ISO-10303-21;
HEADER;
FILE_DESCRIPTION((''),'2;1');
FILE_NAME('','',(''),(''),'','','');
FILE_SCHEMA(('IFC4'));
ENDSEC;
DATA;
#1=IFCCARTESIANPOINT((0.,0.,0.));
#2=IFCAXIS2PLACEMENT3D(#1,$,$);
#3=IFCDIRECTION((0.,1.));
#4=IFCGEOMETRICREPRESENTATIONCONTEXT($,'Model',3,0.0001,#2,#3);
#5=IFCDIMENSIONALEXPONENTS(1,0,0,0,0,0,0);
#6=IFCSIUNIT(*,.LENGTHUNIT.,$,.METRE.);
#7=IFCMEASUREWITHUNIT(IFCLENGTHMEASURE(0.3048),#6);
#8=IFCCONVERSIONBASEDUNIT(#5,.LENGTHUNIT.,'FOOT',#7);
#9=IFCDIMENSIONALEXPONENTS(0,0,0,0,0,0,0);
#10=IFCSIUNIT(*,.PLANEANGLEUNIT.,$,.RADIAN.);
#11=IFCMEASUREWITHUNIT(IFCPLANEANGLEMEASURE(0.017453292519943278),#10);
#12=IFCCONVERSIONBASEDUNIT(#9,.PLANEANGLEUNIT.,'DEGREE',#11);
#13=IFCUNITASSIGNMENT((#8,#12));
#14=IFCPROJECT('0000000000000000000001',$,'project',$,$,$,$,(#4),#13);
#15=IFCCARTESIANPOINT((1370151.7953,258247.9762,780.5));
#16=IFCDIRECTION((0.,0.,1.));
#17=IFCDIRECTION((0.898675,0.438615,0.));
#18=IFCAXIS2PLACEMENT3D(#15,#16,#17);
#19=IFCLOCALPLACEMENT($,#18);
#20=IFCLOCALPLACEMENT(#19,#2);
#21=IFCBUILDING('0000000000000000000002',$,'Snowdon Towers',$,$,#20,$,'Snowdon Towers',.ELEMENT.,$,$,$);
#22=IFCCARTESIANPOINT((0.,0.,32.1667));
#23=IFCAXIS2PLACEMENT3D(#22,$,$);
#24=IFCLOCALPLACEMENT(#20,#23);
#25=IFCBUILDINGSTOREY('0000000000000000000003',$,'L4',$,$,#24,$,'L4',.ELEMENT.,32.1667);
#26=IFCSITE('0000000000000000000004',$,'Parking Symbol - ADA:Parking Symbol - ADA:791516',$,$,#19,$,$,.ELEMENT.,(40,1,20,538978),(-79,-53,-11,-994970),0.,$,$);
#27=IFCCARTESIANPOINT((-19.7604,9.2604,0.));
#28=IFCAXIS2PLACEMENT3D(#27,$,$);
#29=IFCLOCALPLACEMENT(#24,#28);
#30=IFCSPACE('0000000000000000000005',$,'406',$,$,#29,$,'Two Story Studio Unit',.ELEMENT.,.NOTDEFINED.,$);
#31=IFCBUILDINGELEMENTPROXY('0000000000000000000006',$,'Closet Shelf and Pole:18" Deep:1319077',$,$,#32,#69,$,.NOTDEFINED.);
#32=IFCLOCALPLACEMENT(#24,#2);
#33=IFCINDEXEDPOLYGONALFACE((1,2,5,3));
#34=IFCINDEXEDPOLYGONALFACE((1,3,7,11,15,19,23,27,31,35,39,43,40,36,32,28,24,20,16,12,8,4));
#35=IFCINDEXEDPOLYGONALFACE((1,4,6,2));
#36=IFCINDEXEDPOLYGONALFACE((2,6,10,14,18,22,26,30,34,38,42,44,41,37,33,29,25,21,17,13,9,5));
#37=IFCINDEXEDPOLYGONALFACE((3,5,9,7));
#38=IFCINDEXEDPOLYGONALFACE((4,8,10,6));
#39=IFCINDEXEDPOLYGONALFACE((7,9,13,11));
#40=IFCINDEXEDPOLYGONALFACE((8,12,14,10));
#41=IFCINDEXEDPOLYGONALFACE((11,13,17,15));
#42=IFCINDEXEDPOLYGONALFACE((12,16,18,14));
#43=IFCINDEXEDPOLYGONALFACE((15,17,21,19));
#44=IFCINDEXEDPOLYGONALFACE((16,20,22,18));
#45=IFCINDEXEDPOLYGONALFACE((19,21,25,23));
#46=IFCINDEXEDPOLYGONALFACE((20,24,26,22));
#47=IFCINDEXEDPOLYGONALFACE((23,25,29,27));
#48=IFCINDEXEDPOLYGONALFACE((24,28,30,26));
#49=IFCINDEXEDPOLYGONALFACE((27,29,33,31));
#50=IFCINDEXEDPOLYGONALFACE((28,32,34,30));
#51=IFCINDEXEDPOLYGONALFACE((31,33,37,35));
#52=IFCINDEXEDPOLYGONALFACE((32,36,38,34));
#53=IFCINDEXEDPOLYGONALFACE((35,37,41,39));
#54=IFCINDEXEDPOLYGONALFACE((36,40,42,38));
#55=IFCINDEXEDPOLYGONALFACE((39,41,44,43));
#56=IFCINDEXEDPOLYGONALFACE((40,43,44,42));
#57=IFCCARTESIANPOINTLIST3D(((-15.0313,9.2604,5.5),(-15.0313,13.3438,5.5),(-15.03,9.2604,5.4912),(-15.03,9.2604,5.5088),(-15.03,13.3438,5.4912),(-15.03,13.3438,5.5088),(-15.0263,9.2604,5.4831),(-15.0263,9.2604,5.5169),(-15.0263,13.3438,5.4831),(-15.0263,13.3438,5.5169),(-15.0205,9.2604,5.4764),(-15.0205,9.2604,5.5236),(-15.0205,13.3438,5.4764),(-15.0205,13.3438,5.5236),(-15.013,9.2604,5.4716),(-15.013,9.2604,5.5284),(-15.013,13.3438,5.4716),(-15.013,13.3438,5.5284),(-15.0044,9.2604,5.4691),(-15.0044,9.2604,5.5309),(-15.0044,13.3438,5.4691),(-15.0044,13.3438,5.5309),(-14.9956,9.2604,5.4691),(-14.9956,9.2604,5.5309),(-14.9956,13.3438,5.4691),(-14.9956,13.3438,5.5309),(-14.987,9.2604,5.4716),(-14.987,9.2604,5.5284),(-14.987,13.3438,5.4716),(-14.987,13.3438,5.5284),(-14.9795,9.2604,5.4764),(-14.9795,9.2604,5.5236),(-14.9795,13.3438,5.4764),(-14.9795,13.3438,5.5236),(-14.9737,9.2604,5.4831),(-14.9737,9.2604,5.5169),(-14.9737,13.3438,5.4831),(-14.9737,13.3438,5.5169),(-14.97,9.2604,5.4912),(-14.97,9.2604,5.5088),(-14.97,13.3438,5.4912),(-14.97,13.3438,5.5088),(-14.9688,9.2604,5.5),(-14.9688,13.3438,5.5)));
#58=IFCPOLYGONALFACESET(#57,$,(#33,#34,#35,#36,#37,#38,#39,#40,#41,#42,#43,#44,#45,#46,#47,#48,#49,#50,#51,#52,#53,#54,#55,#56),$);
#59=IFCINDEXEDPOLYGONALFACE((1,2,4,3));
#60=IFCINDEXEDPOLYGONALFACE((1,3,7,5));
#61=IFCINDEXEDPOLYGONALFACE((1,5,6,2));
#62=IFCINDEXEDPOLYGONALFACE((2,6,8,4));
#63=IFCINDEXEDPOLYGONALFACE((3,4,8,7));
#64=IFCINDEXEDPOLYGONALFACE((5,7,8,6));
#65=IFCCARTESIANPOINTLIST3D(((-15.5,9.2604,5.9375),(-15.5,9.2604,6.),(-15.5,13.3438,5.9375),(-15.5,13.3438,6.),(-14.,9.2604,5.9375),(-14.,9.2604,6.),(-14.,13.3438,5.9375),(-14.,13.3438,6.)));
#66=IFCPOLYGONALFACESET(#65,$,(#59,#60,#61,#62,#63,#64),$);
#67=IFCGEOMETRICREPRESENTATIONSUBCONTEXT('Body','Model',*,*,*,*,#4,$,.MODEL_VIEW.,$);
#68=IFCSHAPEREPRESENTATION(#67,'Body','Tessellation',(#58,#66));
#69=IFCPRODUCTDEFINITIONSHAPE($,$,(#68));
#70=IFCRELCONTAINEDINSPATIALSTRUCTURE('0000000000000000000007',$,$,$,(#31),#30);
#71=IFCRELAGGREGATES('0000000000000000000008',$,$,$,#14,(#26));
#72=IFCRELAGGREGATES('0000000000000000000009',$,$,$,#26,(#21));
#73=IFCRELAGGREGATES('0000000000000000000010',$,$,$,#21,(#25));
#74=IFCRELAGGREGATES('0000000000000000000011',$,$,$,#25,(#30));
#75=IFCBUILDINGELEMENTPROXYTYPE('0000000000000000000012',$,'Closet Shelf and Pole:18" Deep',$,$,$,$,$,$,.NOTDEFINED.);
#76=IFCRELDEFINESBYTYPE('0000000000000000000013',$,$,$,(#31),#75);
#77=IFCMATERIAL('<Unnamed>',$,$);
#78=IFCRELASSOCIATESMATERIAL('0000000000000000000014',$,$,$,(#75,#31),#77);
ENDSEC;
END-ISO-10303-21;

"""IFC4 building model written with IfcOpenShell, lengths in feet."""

from ifc_helpers import new_model, entity, si_unit, converted_unit, direction, frame, origin, place, context, subcontext, project, spatial, arc, indexed_curve, outline, extrude, source, transform, mapped, material, type_object, type_shapes, element, save


model = new_model("IFC4")

# Units and contexts
model_context = context("Model", 3, precision=0.0001, world=origin(), true_north=direction((0.0, 1.0)))
body_context = subcontext(model_context, "Body", "Model", "MODEL_VIEW")
ifc_project = project(units=[converted_unit("LENGTHUNIT", "FOOT", entity("IfcLengthMeasure", 0.3048), si_unit("LENGTHUNIT", "METRE"), dimensions=[1, 0, 0, 0, 0, 0, 0]), converted_unit("PLANEANGLEUNIT", "DEGREE", entity("IfcPlaneAngleMeasure", 0.017453292519943278), si_unit("PLANEANGLEUNIT", "RADIAN"), dimensions=[0, 0, 0, 0, 0, 0, 0])], contexts=[model_context])

# Site, building, storey
site_placement = place(None, frame((1370151.7953, 258247.9762, 780.5), z_axis=(0.0, 0.0, 1.0), x_axis=(0.898675, 0.438615, 0.0)))
site = spatial("IfcSite", under=ifc_project, at=site_placement, Name="Parking Symbol - ADA:Parking Symbol - ADA:791516", CompositionType="ELEMENT", RefLatitude=(40, 1, 20, 538978), RefLongitude=(-79, -53, -11, -994970), RefElevation=0.0)
building_placement = place(site_placement, origin())
building = spatial("IfcBuilding", under=site, at=building_placement, Name="Snowdon Towers", LongName="Snowdon Towers", CompositionType="ELEMENT")
storey_placement = place(building_placement, frame((0.0, 0.0, 32.1667)))
storey = spatial("IfcBuildingStorey", under=building, at=storey_placement, Name="L4", LongName="L4", CompositionType="ELEMENT", Elevation=32.1667)

# Shared definitions
space_placement = place(storey_placement, frame((-19.7604, 9.2604, 0.0)))
space = spatial("IfcSpace", under=storey, at=space_placement, Name="406", LongName="Two Story Studio Unit", CompositionType="ELEMENT", PredefinedType="NOTDEFINED")

# Building element proxy
ifc_material_1 = material(Name="<Unnamed>")
building_element_proxy_type_1 = type_object("IfcBuildingElementProxyType", Name="Closet Shelf and Pole:18\" Deep", PredefinedType="NOTDEFINED", material=ifc_material_1)
shared_shape_1 = source(origin(), body_context, "Body", "SweptSolid", [
    extrude(outline(indexed_curve([(-0.0312, 0.0), (0.0, -0.0312), (0.0312, 0.0), (0.0, 0.0312)], segments=[arc(1, 2, 3), arc(3, 4, 1)], self_intersect=False)), frame((0.0, -1.0, 5.5), z_axis=(1.0, 0.0, 0.0), x_axis=(0.0, 1.0, 0.0)), (0.0, 0.0, 1.0), 4.0833),
    extrude(outline(indexed_curve([(-2.0417, -0.75), (2.0417, -0.75), (2.0417, 0.75), (-2.0417, 0.75), (-2.0417, -0.75)], self_intersect=False)), frame((2.0417, -0.75, 5.9375), z_axis=(0.0, 0.0, 1.0), x_axis=(-1.0, 0.0, 0.0)), (0.0, 0.0, 1.0), 0.0625),
])
type_shapes(building_element_proxy_type_1, [shared_shape_1])
proxy_1_placement = place(space_placement, frame((5.7604, 4.0833, 0.0), z_axis=(0.0, 0.0, 1.0), x_axis=(0.0, -1.0, 0.0)))
element("IfcBuildingElementProxy", 1, at=proxy_1_placement, inside=space, type_object=building_element_proxy_type_1, material=ifc_material_1, Name="Closet Shelf and Pole:18\" Deep:1319077", PredefinedType="NOTDEFINED", context=body_context, shape_type="MappedRepresentation", body=[
    mapped(shared_shape_1, transform((0.0, 0.0, 0.0), scale=1.0)),
])

save(model, "model.ifc")
